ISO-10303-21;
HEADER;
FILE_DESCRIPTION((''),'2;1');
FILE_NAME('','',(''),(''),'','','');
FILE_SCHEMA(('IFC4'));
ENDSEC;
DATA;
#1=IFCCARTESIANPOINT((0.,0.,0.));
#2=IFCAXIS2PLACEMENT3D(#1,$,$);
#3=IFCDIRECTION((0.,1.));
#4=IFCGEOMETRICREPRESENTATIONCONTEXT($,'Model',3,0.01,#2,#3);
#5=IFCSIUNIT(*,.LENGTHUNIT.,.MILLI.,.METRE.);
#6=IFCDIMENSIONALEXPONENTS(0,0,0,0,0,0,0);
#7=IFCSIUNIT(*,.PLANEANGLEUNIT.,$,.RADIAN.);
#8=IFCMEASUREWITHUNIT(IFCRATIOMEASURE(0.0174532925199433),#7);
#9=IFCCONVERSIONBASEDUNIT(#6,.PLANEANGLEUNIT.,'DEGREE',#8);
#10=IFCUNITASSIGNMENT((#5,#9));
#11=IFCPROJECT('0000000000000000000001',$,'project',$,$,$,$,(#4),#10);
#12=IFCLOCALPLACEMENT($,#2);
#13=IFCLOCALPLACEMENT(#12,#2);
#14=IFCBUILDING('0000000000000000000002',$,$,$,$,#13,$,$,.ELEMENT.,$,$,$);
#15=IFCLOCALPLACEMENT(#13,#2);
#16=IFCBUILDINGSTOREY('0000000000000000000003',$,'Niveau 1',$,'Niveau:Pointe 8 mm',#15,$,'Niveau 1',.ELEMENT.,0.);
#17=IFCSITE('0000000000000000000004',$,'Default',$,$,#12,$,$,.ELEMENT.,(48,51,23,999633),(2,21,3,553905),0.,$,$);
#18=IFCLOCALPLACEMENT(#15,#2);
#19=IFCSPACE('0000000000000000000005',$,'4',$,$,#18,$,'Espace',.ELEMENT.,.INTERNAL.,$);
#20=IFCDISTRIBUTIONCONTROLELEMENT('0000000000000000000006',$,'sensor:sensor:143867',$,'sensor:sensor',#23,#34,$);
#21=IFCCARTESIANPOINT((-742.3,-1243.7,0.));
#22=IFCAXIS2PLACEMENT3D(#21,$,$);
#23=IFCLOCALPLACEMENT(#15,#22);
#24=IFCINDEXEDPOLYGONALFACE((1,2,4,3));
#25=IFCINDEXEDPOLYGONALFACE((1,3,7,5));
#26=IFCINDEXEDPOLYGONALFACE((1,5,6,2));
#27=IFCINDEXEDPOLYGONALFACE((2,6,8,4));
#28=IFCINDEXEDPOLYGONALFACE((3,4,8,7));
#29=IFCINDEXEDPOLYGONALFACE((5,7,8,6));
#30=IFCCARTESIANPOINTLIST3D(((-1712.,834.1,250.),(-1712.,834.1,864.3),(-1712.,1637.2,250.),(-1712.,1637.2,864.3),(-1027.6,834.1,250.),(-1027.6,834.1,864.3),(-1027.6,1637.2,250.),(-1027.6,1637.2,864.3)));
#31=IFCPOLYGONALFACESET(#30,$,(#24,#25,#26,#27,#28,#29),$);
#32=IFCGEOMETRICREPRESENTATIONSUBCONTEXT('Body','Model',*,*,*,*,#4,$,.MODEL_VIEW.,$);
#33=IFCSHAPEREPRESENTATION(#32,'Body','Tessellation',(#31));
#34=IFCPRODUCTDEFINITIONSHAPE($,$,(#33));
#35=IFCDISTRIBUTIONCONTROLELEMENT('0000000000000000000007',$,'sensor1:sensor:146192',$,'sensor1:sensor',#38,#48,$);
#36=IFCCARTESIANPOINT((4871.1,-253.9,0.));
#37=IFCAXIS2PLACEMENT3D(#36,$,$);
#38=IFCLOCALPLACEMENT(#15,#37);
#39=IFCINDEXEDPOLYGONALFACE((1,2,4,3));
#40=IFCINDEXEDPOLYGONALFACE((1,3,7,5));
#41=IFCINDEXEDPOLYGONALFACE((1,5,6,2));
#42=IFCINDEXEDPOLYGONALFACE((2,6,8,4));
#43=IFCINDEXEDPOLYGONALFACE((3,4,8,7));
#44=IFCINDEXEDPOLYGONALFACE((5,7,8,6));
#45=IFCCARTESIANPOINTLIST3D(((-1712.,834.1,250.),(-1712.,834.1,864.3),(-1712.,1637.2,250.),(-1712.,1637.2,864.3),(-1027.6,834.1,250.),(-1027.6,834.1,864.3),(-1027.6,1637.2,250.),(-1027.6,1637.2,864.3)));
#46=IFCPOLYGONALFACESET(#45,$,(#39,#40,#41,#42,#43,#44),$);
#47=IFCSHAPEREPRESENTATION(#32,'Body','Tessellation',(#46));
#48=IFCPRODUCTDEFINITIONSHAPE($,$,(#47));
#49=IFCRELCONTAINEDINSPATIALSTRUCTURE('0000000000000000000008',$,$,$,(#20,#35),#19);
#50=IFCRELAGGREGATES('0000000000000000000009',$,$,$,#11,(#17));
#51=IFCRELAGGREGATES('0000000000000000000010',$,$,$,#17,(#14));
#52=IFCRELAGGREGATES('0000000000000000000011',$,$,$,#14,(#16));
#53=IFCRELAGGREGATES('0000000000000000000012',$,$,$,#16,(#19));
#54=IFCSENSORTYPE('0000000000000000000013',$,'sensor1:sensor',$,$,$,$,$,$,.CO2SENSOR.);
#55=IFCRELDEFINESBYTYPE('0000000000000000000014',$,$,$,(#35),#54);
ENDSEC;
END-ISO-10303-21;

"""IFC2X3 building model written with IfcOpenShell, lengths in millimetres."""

from ifc_helpers import new_model, entity, si_unit, converted_unit, direction, frame, origin, origin_2d_with_axis, place, context, subcontext, project, spatial, rectangle, extrude, source, transform, mapped, type_object, type_shapes, element, save


model = new_model("IFC2X3")

# Units and contexts
model_context = context("Model", 3, precision=0.01, world=origin(), true_north=direction((0.0, 1.0)))
body_context = subcontext(model_context, "Body", "Model", "MODEL_VIEW")
ifc_project = project(units=[si_unit("LENGTHUNIT", "METRE", prefix="MILLI"), converted_unit("PLANEANGLEUNIT", "DEGREE", entity("IfcRatioMeasure", 0.0174532925199433), si_unit("PLANEANGLEUNIT", "RADIAN"), dimensions=[0, 0, 0, 0, 0, 0, 0])], contexts=[model_context])

# Site, building, storey, space
site_placement = place(None, origin())
site = spatial("IfcSite", under=ifc_project, at=site_placement, Name="Default", CompositionType="ELEMENT", RefLatitude=(48, 51, 23, 999633), RefLongitude=(2, 21, 3, 553905), RefElevation=0.0)
building_placement = place(site_placement, origin())
building = spatial("IfcBuilding", under=site, at=building_placement, CompositionType="ELEMENT")
storey_placement = place(building_placement, origin())
storey = spatial("IfcBuildingStorey", under=building, at=storey_placement, Name="Niveau 1", ObjectType="Niveau:Pointe 8 mm", LongName="Niveau 1", CompositionType="ELEMENT", Elevation=0.0)
space_placement = place(storey_placement, origin())
space = spatial("IfcSpace", under=storey, at=space_placement, Name="4", LongName="Espace", CompositionType="ELEMENT", InteriorOrExteriorSpace="INTERNAL")

# Distribution control elements
shared_shape_1 = source(origin(), body_context, "Body", "SweptSolid", [
    extrude(rectangle(XDim=684.5, YDim=803.1, at=origin_2d_with_axis()), frame((-1369.8, 1235.7, 250.0), z_axis=(0.0, 0.0, 1.0), x_axis=(-1.0, 0.0, 0.0)), (0.0, 0.0, 1.0), 614.3),
])
distribution_control_element_1_placement = place(storey_placement, frame((-742.3, -1243.7, 0.0)))
element("IfcDistributionControlElement", 1, at=distribution_control_element_1_placement, inside=space, Name="sensor:sensor:143867", ObjectType="sensor:sensor", context=body_context, shape_type="MappedRepresentation", body=[
    mapped(shared_shape_1, transform((0.0, 0.0, 0.0), scale=1.0)),
])
sensor_type = type_object("IfcSensorType", Name="sensor1:sensor", PredefinedType="CO2SENSOR")
shared_shape_2 = source(origin(), body_context, "Body", "SweptSolid", [
    extrude(rectangle(XDim=684.5, YDim=803.1, at=origin_2d_with_axis()), frame((-1369.8, 1235.7, 250.0), z_axis=(0.0, 0.0, 1.0), x_axis=(-1.0, 0.0, 0.0)), (0.0, 0.0, 1.0), 614.3),
])
type_shapes(sensor_type, [shared_shape_2])
distribution_control_element_2_placement = place(storey_placement, frame((4871.1, -253.9, 0.0)))
element("IfcDistributionControlElement", 2, at=distribution_control_element_2_placement, inside=space, type_object=sensor_type, Name="sensor1:sensor:146192", ObjectType="sensor1:sensor", context=body_context, shape_type="MappedRepresentation", body=[
    mapped(shared_shape_2, transform((0.0, 0.0, 0.0), scale=1.0)),
])

save(model, "model.ifc")
